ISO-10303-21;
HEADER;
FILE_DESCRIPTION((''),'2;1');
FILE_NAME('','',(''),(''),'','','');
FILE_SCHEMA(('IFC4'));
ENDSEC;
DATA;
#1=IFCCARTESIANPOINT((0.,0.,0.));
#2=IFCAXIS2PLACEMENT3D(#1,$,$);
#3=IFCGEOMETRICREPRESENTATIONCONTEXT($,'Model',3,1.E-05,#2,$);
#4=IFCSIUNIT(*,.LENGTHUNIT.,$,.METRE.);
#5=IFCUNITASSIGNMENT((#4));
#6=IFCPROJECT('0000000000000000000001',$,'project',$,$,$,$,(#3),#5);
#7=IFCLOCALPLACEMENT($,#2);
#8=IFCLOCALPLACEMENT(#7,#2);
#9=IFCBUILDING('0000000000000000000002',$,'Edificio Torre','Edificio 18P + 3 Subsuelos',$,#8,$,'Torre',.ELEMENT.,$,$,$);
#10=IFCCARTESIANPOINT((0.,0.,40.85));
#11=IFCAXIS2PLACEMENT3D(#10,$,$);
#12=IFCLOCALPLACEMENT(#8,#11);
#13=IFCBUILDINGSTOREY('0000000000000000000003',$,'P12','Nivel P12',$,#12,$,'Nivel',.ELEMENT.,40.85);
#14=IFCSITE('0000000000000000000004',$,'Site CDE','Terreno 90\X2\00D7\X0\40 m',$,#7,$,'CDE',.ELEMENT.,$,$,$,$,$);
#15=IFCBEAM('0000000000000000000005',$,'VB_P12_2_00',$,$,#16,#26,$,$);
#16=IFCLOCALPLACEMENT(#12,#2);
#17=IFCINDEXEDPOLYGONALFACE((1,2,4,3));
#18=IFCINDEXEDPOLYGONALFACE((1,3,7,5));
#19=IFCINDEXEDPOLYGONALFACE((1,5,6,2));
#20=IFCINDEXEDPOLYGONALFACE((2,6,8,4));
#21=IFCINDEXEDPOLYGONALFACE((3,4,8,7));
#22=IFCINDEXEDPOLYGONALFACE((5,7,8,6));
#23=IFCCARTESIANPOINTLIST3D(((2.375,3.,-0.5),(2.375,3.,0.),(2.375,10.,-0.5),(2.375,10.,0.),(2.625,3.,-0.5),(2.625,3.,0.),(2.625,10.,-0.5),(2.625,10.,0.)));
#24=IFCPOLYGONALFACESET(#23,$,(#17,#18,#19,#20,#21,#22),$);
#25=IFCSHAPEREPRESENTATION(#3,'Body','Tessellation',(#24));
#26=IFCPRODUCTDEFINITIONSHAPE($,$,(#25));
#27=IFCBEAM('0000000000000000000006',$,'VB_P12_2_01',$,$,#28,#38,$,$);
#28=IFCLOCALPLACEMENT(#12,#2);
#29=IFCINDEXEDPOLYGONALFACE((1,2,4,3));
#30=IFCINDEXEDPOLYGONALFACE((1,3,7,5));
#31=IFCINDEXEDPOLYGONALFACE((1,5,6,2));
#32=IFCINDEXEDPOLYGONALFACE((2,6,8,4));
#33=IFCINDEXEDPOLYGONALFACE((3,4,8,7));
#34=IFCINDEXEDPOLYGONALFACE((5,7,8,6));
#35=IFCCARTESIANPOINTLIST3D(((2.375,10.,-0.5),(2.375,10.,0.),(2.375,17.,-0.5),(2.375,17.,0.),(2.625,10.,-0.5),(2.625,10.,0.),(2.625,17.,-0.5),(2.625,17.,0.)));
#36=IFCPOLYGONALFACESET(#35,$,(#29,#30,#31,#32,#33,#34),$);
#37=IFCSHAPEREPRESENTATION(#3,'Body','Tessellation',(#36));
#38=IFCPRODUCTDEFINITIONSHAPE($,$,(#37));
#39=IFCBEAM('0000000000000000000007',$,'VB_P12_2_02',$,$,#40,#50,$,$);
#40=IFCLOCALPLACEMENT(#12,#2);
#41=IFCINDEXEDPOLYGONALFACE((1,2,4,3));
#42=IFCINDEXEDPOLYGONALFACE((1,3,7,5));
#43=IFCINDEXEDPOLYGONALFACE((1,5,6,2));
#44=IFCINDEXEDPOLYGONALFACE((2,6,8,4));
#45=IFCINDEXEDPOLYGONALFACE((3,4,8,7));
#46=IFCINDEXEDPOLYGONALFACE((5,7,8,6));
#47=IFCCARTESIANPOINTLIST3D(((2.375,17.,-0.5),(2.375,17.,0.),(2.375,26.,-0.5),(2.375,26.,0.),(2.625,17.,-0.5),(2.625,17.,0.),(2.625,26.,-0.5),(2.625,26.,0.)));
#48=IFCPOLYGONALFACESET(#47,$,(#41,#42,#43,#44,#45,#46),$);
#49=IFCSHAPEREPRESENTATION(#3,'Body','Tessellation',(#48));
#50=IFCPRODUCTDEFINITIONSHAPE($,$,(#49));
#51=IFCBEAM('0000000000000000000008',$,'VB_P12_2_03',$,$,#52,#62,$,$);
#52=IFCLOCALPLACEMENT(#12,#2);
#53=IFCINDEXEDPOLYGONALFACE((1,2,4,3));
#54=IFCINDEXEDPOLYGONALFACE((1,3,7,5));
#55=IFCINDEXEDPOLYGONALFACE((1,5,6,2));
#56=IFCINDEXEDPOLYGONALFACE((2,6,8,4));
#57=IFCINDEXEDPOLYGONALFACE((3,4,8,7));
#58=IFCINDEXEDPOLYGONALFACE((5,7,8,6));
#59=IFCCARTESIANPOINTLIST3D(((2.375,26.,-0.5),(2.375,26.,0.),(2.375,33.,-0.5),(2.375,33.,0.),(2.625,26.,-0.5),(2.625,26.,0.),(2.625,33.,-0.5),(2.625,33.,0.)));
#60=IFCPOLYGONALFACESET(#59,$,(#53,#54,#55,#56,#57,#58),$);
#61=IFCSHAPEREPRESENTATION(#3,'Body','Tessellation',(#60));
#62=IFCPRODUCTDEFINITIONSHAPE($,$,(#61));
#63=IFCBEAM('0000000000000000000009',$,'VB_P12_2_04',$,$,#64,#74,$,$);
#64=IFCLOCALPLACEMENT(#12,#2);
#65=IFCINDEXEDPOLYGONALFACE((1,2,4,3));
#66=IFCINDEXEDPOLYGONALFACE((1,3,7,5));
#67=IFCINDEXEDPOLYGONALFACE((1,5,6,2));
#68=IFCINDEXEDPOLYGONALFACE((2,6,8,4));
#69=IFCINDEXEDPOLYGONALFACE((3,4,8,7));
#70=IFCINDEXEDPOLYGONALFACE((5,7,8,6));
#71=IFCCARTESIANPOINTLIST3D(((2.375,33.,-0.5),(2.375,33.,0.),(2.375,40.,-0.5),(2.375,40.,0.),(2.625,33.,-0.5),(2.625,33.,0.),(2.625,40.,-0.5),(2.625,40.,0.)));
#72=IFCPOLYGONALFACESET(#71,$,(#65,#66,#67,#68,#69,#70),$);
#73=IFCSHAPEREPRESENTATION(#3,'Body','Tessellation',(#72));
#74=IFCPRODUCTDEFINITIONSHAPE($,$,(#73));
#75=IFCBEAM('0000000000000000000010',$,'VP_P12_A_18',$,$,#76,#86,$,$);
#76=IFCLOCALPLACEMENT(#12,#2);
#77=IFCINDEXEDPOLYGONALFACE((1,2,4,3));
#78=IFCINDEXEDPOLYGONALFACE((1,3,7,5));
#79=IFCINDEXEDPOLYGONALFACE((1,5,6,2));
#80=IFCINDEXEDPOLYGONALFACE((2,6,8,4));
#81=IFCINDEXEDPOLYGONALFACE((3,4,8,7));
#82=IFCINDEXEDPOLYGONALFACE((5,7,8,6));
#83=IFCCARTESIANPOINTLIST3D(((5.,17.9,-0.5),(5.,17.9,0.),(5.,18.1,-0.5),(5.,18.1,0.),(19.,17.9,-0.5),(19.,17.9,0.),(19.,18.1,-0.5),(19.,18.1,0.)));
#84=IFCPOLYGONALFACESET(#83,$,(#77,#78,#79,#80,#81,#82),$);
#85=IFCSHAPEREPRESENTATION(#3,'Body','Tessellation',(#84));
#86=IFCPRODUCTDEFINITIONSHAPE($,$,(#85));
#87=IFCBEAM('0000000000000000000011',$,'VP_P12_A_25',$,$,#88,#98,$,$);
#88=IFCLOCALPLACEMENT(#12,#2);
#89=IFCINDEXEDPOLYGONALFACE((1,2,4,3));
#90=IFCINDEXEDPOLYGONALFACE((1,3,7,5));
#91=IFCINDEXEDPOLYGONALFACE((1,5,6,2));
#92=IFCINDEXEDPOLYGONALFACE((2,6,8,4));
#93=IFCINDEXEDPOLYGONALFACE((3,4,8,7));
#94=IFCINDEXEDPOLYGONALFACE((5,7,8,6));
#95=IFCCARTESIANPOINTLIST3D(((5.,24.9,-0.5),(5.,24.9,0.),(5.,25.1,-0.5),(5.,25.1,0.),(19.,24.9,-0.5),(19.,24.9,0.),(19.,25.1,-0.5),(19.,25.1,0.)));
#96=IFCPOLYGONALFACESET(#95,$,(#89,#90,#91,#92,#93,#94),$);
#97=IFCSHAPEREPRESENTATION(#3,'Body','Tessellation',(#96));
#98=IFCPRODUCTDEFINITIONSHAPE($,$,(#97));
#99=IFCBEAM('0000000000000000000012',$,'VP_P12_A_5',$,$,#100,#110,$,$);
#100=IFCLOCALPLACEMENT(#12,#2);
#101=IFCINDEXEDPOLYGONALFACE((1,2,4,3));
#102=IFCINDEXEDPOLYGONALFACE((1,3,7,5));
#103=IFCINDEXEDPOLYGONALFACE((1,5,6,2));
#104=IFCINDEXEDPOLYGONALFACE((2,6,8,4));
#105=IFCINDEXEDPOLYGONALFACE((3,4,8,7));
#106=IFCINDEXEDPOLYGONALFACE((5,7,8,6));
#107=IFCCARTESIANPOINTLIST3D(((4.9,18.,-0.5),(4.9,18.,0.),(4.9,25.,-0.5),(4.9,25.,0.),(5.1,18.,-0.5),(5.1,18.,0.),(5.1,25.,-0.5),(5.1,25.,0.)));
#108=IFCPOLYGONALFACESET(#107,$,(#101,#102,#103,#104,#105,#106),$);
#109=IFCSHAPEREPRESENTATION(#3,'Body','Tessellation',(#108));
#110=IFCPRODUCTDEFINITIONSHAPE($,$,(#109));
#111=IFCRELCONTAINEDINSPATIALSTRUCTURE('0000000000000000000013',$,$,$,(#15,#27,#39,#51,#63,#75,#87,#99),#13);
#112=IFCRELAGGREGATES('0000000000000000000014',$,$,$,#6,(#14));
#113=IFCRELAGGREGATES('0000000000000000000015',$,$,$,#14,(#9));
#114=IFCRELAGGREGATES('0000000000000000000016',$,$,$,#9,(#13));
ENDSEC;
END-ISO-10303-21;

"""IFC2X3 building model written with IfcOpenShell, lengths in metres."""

from ifc_helpers import new_model, si_unit, frame, origin, origin_2d, place, context, project, spatial, rectangle, extrude, element, save


model = new_model("IFC2X3")

# Units and contexts
model_context = context("Model", 3, precision=1e-05, world=origin())
ifc_project = project(units=[si_unit("LENGTHUNIT", "METRE")], contexts=[model_context])

# Site, building, storey
site_placement = place(None, origin())
site = spatial("IfcSite", under=ifc_project, at=site_placement, Name="Site CDE", Description="Terreno 90×40 m", LongName="CDE", CompositionType="ELEMENT")
building_placement = place(site_placement, origin())
building = spatial("IfcBuilding", under=site, at=building_placement, Name="Edificio Torre", Description="Edificio 18P + 3 Subsuelos", LongName="Torre", CompositionType="ELEMENT")
storey_placement = place(building_placement, frame((0.0, 0.0, 40.85)))
storey = spatial("IfcBuildingStorey", under=building, at=storey_placement, Name="P12", Description="Nivel P12", LongName="Nivel", CompositionType="ELEMENT", Elevation=40.85)

# Beams
for number, where, name in (
    (1, (2.5, 6.5, -0.5), "VB_P12_2_00"),
    (2, (2.5, 13.5, -0.5), "VB_P12_2_01"),
):
    element("IfcBeam", number, at=place(storey_placement, frame(where)), inside=storey, Name=name, context=model_context, shape_type="SweptSolid", body=[
        extrude(rectangle(XDim=0.25, YDim=7.0, at=origin_2d()), origin(), (0.0, 0.0, 1.0), 0.5),
    ])
beam_1_placement = place(storey_placement, frame((2.5, 21.5, -0.5)))
element("IfcBeam", 3, at=beam_1_placement, inside=storey, Name="VB_P12_2_02", context=model_context, shape_type="SweptSolid", body=[
    extrude(rectangle(XDim=0.25, YDim=9.0, at=origin_2d()), origin(), (0.0, 0.0, 1.0), 0.5),
])
for number, where, name in (
    (4, (2.5, 29.5, -0.5), "VB_P12_2_03"),
    (5, (2.5, 36.5, -0.5), "VB_P12_2_04"),
):
    element("IfcBeam", number, at=place(storey_placement, frame(where)), inside=storey, Name=name, context=model_context, shape_type="SweptSolid", body=[
        extrude(rectangle(XDim=0.25, YDim=7.0, at=origin_2d()), origin(), (0.0, 0.0, 1.0), 0.5),
    ])
for number, where, name in (
    (6, (12.0, 18.0, -0.5), "VP_P12_A_18"),
    (7, (12.0, 25.0, -0.5), "VP_P12_A_25"),
):
    element("IfcBeam", number, at=place(storey_placement, frame(where)), inside=storey, Name=name, context=model_context, shape_type="SweptSolid", body=[
        extrude(rectangle(XDim=14.0, YDim=0.2, at=origin_2d()), origin(), (0.0, 0.0, 1.0), 0.5),
    ])
beam_2_placement = place(storey_placement, frame((5.0, 21.5, -0.5)))
element("IfcBeam", 8, at=beam_2_placement, inside=storey, Name="VP_P12_A_5", context=model_context, shape_type="SweptSolid", body=[
    extrude(rectangle(XDim=0.2, YDim=7.0, at=origin_2d()), origin(), (0.0, 0.0, 1.0), 0.5),
])

save(model, "model.ifc")
